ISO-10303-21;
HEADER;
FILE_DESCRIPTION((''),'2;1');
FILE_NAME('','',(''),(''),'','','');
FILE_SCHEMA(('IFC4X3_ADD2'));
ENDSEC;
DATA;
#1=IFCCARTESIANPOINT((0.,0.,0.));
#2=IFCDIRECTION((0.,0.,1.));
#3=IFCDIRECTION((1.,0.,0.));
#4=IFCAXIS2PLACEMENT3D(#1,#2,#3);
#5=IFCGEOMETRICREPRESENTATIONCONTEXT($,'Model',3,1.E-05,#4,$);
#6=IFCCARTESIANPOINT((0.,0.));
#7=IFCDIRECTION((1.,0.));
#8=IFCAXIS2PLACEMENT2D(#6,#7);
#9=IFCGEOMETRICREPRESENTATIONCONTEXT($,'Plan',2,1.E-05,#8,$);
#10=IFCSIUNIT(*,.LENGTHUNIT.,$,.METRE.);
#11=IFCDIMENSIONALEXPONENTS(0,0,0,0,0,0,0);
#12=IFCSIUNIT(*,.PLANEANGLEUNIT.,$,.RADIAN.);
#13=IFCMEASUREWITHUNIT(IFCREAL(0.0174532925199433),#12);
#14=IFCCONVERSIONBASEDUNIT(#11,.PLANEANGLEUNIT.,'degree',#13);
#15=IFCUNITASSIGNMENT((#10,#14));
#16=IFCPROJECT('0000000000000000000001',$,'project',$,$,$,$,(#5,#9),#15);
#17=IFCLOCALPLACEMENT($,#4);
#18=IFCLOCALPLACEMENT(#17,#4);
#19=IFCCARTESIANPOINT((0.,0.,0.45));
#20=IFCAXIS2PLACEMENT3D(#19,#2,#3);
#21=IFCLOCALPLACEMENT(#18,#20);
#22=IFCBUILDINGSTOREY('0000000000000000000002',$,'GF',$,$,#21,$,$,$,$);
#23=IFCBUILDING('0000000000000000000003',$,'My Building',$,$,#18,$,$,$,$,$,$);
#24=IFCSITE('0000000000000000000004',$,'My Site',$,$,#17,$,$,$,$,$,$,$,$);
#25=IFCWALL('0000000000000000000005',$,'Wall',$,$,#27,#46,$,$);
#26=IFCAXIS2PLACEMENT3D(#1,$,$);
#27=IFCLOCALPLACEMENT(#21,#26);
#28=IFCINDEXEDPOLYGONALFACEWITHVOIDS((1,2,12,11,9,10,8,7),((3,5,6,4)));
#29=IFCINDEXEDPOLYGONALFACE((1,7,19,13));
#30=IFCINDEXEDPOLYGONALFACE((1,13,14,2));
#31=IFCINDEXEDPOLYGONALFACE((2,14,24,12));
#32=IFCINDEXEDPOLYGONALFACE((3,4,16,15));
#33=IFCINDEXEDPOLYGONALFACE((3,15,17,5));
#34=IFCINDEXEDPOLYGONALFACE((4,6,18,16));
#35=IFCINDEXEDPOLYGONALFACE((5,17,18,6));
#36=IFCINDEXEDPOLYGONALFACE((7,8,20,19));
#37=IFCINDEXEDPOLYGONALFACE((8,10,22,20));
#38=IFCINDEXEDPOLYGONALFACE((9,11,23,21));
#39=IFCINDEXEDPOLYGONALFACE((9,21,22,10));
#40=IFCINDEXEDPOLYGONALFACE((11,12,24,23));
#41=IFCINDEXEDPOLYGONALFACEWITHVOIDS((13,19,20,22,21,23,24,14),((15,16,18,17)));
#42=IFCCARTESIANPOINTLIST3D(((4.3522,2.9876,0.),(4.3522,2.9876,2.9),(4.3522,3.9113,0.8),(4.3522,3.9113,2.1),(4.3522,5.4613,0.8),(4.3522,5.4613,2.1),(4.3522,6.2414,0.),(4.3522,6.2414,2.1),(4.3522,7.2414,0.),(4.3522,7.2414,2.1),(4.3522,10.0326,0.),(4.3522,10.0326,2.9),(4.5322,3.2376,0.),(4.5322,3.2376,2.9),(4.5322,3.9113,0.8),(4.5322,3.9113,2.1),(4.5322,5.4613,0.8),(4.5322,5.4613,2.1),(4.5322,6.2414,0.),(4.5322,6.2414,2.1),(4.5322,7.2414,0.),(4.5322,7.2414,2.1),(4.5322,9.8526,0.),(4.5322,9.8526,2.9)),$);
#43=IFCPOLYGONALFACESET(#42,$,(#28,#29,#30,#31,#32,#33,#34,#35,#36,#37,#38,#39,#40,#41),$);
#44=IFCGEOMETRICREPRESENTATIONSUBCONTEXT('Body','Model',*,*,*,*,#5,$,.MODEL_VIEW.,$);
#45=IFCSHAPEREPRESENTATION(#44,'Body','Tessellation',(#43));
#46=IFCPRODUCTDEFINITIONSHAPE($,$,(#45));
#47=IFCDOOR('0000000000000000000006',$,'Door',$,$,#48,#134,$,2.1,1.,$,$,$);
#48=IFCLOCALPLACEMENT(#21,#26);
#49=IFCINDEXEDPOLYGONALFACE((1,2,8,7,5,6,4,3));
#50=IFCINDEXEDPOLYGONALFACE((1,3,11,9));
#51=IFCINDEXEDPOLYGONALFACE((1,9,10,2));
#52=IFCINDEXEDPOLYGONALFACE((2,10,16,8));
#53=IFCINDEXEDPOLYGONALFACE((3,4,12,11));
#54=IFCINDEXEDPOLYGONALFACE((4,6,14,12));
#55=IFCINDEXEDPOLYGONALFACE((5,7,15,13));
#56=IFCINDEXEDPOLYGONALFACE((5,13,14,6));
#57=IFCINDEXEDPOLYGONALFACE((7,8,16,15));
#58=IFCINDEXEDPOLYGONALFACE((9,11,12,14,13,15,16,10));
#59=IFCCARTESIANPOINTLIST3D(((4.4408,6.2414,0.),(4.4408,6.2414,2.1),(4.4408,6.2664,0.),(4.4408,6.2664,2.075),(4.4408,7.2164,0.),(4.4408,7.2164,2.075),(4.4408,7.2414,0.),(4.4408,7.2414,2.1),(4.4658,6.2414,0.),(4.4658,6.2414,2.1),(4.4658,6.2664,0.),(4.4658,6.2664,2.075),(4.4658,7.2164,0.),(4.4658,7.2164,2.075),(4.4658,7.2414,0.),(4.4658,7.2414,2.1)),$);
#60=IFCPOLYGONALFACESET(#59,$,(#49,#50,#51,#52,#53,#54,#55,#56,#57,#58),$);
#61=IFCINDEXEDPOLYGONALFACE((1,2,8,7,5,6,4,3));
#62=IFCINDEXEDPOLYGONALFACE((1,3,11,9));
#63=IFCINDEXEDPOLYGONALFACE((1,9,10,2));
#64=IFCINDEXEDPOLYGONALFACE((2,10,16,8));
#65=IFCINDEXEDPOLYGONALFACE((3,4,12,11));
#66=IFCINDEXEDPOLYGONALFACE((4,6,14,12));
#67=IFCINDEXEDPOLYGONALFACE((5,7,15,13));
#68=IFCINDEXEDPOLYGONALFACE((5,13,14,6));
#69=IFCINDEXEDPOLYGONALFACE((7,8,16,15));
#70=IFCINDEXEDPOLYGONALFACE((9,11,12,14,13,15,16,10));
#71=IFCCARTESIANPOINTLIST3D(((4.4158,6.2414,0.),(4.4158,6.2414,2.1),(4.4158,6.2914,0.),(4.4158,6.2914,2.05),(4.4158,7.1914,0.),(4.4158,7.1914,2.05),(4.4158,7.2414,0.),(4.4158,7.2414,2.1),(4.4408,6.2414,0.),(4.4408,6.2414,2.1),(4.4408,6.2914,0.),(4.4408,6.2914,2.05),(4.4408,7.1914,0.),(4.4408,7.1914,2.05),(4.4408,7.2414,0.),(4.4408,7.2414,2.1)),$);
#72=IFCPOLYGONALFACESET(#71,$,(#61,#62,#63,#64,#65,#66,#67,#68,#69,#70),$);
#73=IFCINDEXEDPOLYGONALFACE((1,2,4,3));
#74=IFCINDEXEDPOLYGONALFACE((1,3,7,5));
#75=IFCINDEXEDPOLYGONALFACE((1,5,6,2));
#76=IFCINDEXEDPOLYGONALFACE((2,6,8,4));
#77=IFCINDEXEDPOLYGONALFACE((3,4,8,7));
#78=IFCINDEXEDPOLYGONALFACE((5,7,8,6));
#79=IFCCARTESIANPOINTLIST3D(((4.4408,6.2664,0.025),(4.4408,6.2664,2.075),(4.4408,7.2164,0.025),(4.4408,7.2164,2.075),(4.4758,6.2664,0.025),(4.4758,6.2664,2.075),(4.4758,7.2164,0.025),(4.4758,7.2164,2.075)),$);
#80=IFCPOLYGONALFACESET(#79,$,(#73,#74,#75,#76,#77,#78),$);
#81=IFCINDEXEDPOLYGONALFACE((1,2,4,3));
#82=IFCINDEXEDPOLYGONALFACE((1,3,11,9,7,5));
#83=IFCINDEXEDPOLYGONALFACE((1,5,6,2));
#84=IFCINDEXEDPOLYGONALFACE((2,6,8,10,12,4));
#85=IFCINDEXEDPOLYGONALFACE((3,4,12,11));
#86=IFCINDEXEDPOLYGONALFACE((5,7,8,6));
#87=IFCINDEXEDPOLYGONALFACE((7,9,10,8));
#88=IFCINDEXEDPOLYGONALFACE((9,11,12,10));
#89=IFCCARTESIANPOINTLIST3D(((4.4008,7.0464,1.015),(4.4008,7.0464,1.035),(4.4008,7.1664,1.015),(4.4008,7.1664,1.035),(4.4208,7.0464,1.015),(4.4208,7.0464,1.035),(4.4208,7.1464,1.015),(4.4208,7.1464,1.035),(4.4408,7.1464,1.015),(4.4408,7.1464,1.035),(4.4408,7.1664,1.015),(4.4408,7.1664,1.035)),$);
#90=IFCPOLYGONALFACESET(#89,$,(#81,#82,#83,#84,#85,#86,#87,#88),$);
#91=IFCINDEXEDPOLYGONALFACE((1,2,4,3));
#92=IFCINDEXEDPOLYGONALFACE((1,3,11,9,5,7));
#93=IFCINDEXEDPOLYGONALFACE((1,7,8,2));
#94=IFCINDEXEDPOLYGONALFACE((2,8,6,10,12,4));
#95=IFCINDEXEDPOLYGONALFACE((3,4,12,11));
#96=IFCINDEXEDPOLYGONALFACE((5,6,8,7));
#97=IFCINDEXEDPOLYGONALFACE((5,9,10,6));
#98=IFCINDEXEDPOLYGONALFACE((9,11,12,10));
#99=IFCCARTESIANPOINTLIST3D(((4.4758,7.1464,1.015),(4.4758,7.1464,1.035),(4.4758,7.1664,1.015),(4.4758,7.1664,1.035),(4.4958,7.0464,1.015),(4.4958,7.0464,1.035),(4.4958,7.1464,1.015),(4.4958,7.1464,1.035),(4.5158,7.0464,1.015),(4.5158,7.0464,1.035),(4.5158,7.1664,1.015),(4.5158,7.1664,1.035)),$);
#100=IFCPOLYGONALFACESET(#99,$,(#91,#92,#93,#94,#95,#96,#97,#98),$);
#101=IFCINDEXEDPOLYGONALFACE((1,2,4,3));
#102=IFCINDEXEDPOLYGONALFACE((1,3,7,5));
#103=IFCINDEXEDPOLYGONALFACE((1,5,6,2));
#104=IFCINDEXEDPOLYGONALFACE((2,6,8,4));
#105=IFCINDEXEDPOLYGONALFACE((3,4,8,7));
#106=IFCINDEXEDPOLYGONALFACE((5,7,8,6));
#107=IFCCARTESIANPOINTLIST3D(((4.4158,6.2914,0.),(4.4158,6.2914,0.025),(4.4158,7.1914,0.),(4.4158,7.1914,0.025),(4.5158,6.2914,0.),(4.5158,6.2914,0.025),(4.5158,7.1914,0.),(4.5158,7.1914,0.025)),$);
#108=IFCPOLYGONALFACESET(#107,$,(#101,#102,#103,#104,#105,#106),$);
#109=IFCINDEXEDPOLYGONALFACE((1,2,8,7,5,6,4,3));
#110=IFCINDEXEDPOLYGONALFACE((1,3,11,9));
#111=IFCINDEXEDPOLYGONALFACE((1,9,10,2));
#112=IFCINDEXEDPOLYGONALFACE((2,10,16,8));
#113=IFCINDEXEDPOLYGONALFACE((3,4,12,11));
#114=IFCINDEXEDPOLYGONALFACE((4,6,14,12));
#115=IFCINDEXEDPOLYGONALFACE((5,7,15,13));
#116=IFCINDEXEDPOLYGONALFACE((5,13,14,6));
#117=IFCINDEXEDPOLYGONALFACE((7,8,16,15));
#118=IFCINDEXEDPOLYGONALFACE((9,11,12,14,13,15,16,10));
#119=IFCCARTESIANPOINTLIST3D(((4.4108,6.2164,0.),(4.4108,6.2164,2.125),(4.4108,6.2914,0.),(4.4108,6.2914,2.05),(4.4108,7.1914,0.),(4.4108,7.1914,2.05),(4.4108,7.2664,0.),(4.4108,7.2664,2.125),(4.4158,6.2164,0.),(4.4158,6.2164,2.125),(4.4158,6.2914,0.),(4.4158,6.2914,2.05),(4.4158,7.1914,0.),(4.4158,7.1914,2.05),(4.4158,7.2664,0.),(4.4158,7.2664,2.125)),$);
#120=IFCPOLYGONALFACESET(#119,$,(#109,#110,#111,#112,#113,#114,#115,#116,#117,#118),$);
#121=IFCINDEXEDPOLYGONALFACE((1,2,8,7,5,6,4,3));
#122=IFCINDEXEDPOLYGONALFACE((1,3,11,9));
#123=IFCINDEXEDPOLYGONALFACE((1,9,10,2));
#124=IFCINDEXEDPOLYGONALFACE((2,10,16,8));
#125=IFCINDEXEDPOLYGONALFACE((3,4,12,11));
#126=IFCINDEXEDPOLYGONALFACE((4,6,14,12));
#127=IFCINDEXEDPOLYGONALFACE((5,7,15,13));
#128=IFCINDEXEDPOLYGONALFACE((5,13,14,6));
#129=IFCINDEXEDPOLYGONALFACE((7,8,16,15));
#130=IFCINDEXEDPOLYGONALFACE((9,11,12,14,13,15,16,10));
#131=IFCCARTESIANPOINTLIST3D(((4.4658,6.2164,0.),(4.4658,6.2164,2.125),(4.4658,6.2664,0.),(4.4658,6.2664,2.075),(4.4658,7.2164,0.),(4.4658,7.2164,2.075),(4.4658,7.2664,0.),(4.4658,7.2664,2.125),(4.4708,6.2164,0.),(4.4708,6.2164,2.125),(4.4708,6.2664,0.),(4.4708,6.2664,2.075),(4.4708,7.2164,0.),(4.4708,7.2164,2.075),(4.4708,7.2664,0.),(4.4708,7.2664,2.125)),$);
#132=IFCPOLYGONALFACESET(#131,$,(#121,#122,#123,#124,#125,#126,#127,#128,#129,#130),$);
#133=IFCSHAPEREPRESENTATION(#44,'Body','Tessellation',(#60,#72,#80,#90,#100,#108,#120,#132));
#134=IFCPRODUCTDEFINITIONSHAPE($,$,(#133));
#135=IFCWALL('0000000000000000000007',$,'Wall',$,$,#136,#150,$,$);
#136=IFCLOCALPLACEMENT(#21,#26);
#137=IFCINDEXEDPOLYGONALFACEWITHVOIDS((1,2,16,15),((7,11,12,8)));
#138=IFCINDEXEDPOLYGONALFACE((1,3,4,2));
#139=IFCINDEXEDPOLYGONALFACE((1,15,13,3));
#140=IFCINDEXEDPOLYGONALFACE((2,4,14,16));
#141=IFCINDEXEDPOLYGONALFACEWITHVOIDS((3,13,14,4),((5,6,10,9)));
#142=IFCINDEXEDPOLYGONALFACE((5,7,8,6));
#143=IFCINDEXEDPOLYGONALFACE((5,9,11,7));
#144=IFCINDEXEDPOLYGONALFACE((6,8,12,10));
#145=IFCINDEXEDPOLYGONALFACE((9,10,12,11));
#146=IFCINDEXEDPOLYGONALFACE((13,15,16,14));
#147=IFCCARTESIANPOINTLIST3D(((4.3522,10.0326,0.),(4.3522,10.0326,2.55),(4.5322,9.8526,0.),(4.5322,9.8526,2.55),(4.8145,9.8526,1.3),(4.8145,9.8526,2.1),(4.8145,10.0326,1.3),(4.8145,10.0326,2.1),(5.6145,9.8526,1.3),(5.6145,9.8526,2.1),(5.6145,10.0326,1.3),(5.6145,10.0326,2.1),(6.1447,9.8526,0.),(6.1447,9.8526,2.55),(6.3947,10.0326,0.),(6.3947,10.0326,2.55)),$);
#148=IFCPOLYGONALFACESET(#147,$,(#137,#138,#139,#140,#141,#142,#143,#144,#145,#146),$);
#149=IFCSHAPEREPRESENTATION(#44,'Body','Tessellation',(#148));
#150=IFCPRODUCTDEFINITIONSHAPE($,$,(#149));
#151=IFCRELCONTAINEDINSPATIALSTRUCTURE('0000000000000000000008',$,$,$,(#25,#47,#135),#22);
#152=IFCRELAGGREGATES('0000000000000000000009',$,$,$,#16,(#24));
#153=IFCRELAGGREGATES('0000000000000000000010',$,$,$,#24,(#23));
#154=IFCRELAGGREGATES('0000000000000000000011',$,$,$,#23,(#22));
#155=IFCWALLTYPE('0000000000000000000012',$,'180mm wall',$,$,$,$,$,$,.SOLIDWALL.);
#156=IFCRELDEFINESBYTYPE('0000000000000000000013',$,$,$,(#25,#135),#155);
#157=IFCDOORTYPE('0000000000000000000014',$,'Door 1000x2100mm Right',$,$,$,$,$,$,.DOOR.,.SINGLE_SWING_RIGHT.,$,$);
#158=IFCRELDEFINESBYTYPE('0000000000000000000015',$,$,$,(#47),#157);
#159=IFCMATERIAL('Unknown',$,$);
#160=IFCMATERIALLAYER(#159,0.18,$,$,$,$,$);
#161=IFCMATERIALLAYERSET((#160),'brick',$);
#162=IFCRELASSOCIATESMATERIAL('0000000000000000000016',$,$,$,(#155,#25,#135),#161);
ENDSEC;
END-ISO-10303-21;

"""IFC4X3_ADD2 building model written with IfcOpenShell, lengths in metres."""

from ifc_helpers import new_model, entity, si_unit, converted_unit, frame, origin_with_axes, origin_2d_with_axis, place, context, subcontext, project, spatial, line, indexed_curve, outline, extrude, shape, source, transform, mapped, material, layer, layer_set, layer_usage, type_object, type_shapes, element, fill, save


model = new_model("IFC4X3_ADD2")

# Units and contexts
model_context = context("Model", 3, precision=1e-05, world=origin_with_axes())
plan_context = context("Plan", 2, precision=1e-05, world=origin_2d_with_axis())
body_context_1 = subcontext(model_context, "Body", "Model", "MODEL_VIEW")
body_context_2 = subcontext(plan_context, "Body", "Plan", "PLAN_VIEW")
ifc_project = project(units=[si_unit("LENGTHUNIT", "METRE"), converted_unit("PLANEANGLEUNIT", "degree", entity("IfcReal", 0.0174532925199433), si_unit("PLANEANGLEUNIT", "RADIAN"), dimensions=[0, 0, 0, 0, 0, 0, 0])], contexts=[model_context, plan_context])

# Site, building, storey
site_placement = place(None, origin_with_axes())
site = spatial("IfcSite", under=ifc_project, at=site_placement, Name="My Site")
building_placement = place(site_placement, origin_with_axes())
building = spatial("IfcBuilding", under=site, at=building_placement, Name="My Building")
storey_placement = place(building_placement, frame((0.0, 0.0, 0.45), z_axis=(0.0, 0.0, 1.0), x_axis=(1.0, 0.0, 0.0)))
storey = spatial("IfcBuildingStorey", under=building, at=storey_placement, Name="GF")

# Shared definitions
ifc_material_1 = material(Name="Unknown")
shared_shape_1 = source(origin_with_axes(), body_context_1, "Body", "SweptSolid", [
    extrude(outline(indexed_curve([(0.0, 0.0), (1.55, 0.0), (1.55, 1.3), (0.0, 1.3)], segments=[line(1, 2, 3, 4, 1)])), frame((-0.775, -0.6, 0.0), z_axis=(0.0, -1.0, 0.0), x_axis=(1.0, 0.0, 0.0)), (0.0, 0.0, -1.0), 1.2),
])
shared_shape_2 = source(origin_with_axes(), body_context_1, "Body", "SweptSolid", [
    extrude(outline(indexed_curve([(0.0, 0.0), (0.8, 0.0), (0.8, 0.8), (0.0, 0.8)], segments=[line(1, 2, 3, 4, 1)])), frame((-0.4, -0.6, 0.0), z_axis=(0.0, -1.0, 0.0), x_axis=(1.0, 0.0, 0.0)), (0.0, 0.0, -1.0), 1.2),
])

# Wall, openings, door
ifc_layer_1 = layer(ifc_material_1, 0.18)
ifc_layer_set_1 = layer_set([ifc_layer_1], Name="brick")
ifc_layer_usage_1 = layer_usage(ifc_layer_set_1, "AXIS2", "POSITIVE", 0.0)
wall_type_1 = type_object("IfcWallType", Name="180mm wall", PredefinedType="SOLIDWALL", material=ifc_layer_set_1)
wall_1_placement = place(storey_placement, frame((4.5322, 2.9876, 0.0), z_axis=(0.0, 0.0, 1.0), x_axis=(0.0, 1.0, 0.0)))
wall_1 = element("IfcWall", 1, at=wall_1_placement, inside=storey, type_object=wall_type_1, material=ifc_layer_usage_1, Name="Wall", context=body_context_1, shape_type="SweptSolid", body=[
    extrude(outline(indexed_curve([(0.25, 0.0), (0.0, 0.18), (7.045, 0.18), (6.865, 0.0)], segments=[line(1, 2, 3, 4, 1)])), origin_with_axes(), (0.0, 0.0, 1.0), 2.9),
])
shared_shape_3 = source(origin_with_axes(), body_context_1, "Body", "SolidModel", [
    extrude(outline(indexed_curve([(0.0, 0.0), (1.0, 0.0), (1.0, 2.1), (0.0, 2.1)], segments=[line(1, 2, 3, 4, 1)])), frame((0.0, -0.6, 0.0), z_axis=(0.0, -1.0, 0.0), x_axis=(1.0, 0.0, 0.0)), (0.0, 0.0, -1.0), 1.2),
])
opening_1_placement = place(wall_1_placement, frame((4.2539, 0.1164, 0.0), z_axis=(0.0, 0.0, 1.0), x_axis=(-1.0, 0.0, 0.0)))
opening_1 = element("IfcOpeningElement", 2, at=opening_1_placement, cuts=wall_1, PredefinedType="OPENING", context=body_context_1, shape_type="MappedRepresentation", body=[
    mapped(shared_shape_3, transform((0.0, 0.0, 0.0), x_axis=(1.0, 0.0, 0.0), y_axis=(0.0, 1.0, 0.0), z_axis=(0.0, 0.0, 1.0), scale=1.0)),
])
opening_2_placement = place(wall_1_placement, frame((1.6987, 0.0, 0.8), z_axis=(0.0, 0.0, 1.0), x_axis=(1.0, 0.0, 0.0)))
element("IfcOpeningElement", 3, at=opening_2_placement, cuts=wall_1, PredefinedType="OPENING", context=body_context_1, shape_type="MappedRepresentation", body=[
    mapped(shared_shape_1, transform((0.0, 0.0, 0.0), x_axis=(1.0, 0.0, 0.0), y_axis=(0.0, 1.0, 0.0), z_axis=(0.0, 0.0, 1.0), scale=1.0)),
])
door_type_1 = type_object("IfcDoorType", Name="Door 1000x2100mm Right", OperationType="SINGLE_SWING_RIGHT", PredefinedType="DOOR")
shared_shape_4 = source(origin_with_axes(), body_context_1, "Body", "SweptSolid", [
    extrude(outline(indexed_curve([(0.0, 0.0), (0.0, 2.1), (1.0, 2.1), (1.0, 0.0), (0.975, 0.0), (0.975, 2.075), (0.025, 2.075), (0.025, 0.0)], segments=[line(1, 2, 3, 4, 5, 6, 7, 8, 1)])), frame((0.0, 0.025, 0.0), z_axis=(0.0, -1.0, 0.0), x_axis=(1.0, 0.0, 0.0)), (0.0, 0.0, -1.0), 0.025),
    extrude(outline(indexed_curve([(0.0, 0.0), (0.0, 2.1), (1.0, 2.1), (1.0, 0.0), (0.95, 0.0), (0.95, 2.05), (0.05, 2.05), (0.05, 0.0)], segments=[line(1, 2, 3, 4, 5, 6, 7, 8, 1)])), frame((0.0, 0.0, 0.0), z_axis=(0.0, -1.0, 0.0), x_axis=(1.0, 0.0, 0.0)), (0.0, 0.0, -1.0), 0.025),
    extrude(outline(indexed_curve([(0.0, 0.0), (0.95, 0.0), (0.95, 0.035), (0.0, 0.035)], segments=[line(1, 2, 3, 4, 1)])), frame((0.025, 0.025, 0.025), z_axis=(0.0, 0.0, 1.0), x_axis=(1.0, 0.0, 0.0)), (0.0, 0.0, 1.0), 2.05),
    extrude(outline(indexed_curve([(0.0, 0.0), (0.0, -0.04), (0.12, -0.04), (0.12, -0.02), (0.02, -0.02), (0.02, 0.0)], segments=[line(1, 2, 3, 4, 5, 6, 1)])), frame((0.075, 0.025, 1.015), z_axis=(0.0, 0.0, 1.0), x_axis=(1.0, 0.0, 0.0)), (0.0, 0.0, 1.0), 0.02),
    extrude(outline(indexed_curve([(0.0, 0.0), (0.0, 0.04), (0.12, 0.04), (0.12, 0.02), (0.02, 0.02), (0.02, 0.0)], segments=[line(1, 2, 3, 4, 5, 6, 1)])), frame((0.075, 0.06, 1.015), z_axis=(0.0, 0.0, 1.0), x_axis=(1.0, 0.0, 0.0)), (0.0, 0.0, 1.0), 0.02),
    extrude(outline(indexed_curve([(0.0, 0.0), (0.9, 0.0), (0.9, 0.1), (0.0, 0.1)], segments=[line(1, 2, 3, 4, 1)])), frame((0.05, 0.0, 0.0), z_axis=(0.0, 0.0, 1.0), x_axis=(1.0, 0.0, 0.0)), (0.0, 0.0, 1.0), 0.025),
    extrude(outline(indexed_curve([(0.0, 0.0), (0.0, 2.125), (1.05, 2.125), (1.05, 0.0), (0.975, 0.0), (0.975, 2.05), (0.075, 2.05), (0.075, 0.0)], segments=[line(1, 2, 3, 4, 5, 6, 7, 8, 1)])), frame((-0.025, -0.005, 0.0), z_axis=(0.0, -1.0, 0.0), x_axis=(1.0, 0.0, 0.0)), (0.0, 0.0, -1.0), 0.005),
    extrude(outline(indexed_curve([(0.0, 0.0), (0.0, 2.125), (1.05, 2.125), (1.05, 0.0), (1.0, 0.0), (1.0, 2.075), (0.05, 2.075), (0.05, 0.0)], segments=[line(1, 2, 3, 4, 5, 6, 7, 8, 1)])), frame((-0.025, 0.05, 0.0), z_axis=(0.0, -1.0, 0.0), x_axis=(1.0, 0.0, 0.0)), (0.0, 0.0, -1.0), 0.005),
])
shared_shape_5 = source(origin_with_axes(), body_context_2, "Body", "Curve2D", [
    entity("IfcIndexedPolyCurve", entity("IfcCartesianPointList2D", [[0.0, 0.0], [0.0, 0.05], [0.025, 0.05], [0.025, 0.025], [0.05, 0.025], [0.05, 0.0]]), [entity("IfcLineIndex", [1, 2, 3, 4, 5, 6, 1])]),
    entity("IfcIndexedPolyCurve", entity("IfcCartesianPointList2D", [[1.0, 0.0], [1.0, 0.05], [0.975, 0.05], [0.975, 0.025], [0.95, 0.025], [0.95, 0.0]]), [entity("IfcLineIndex", [1, 2, 3, 4, 5, 6, 1])]),
    entity("IfcTrimmedCurve", entity("IfcEllipse", entity("IfcAxis2Placement2D", entity("IfcCartesianPoint", [0.94, 0.05]), entity("IfcDirection", [1.0, 0.0])), 0.915, 0.95), [entity("IfcCartesianPoint", [0.94, 1.0])], [entity("IfcCartesianPoint", [0.025, 0.05])], True, "CARTESIAN"),
    entity("IfcIndexedPolyCurve", entity("IfcCartesianPointList2D", [[0.975, 0.05], [0.94, 0.05], [0.94, 1.0], [0.975, 1.0]]), [entity("IfcLineIndex", [1, 2, 3, 4, 1])]),
])
type_shapes(door_type_1, [shared_shape_4, shared_shape_5])
door_1_placement = place(opening_1_placement, frame((0.0, 0.0, 0.0), z_axis=(0.0, 0.0, 1.0), x_axis=(1.0, 0.0, 0.0)))
door_1 = element("IfcDoor", 4, at=door_1_placement, inside=storey, type_object=door_type_1, Name="Door", OverallHeight=2.1, OverallWidth=1.0, shapes=[
    shape(body_context_1, "Body", "MappedRepresentation", [mapped(shared_shape_4, transform((0.0, 0.0, 0.0), x_axis=(1.0, 0.0, 0.0), y_axis=(0.0, 1.0, 0.0), z_axis=(0.0, 0.0, 1.0), scale=1.0))]),
    shape(body_context_2, "Body", "MappedRepresentation", [mapped(shared_shape_5, transform((0.0, 0.0, 0.0), x_axis=(1.0, 0.0, 0.0), y_axis=(0.0, 1.0, 0.0), z_axis=(0.0, 0.0, 1.0), scale=1.0))]),
])
fill(opening_1, door_1)

# Wall, opening
ifc_layer_usage_2 = layer_usage(ifc_layer_set_1, "AXIS2", "POSITIVE", 0.0)
wall_2_placement = place(storey_placement, frame((6.3947, 10.0326, 0.0), z_axis=(0.0, 0.0, 1.0), x_axis=(-1.0, 0.0, 0.0)))
wall_2 = element("IfcWall", 5, at=wall_2_placement, inside=storey, type_object=wall_type_1, material=ifc_layer_usage_2, Name="Wall", context=body_context_1, shape_type="SweptSolid", body=[
    extrude(outline(indexed_curve([(0.0, 0.0), (0.25, 0.18), (1.8625, 0.18), (2.0425, 0.0)], segments=[line(1, 2, 3, 4, 1)])), origin_with_axes(), (0.0, 0.0, 1.0), 2.55),
])
opening_3_placement = place(wall_2_placement, frame((1.1802, 0.0422, 1.3), z_axis=(0.0, 0.0, 1.0), x_axis=(1.0, 0.0, 0.0)))
element("IfcOpeningElement", 6, at=opening_3_placement, cuts=wall_2, PredefinedType="OPENING", context=body_context_1, shape_type="MappedRepresentation", body=[
    mapped(shared_shape_2, transform((0.0, 0.0, 0.0), x_axis=(1.0, 0.0, 0.0), y_axis=(0.0, 1.0, 0.0), z_axis=(0.0, 0.0, 1.0), scale=1.0)),
])

save(model, "model.ifc")
